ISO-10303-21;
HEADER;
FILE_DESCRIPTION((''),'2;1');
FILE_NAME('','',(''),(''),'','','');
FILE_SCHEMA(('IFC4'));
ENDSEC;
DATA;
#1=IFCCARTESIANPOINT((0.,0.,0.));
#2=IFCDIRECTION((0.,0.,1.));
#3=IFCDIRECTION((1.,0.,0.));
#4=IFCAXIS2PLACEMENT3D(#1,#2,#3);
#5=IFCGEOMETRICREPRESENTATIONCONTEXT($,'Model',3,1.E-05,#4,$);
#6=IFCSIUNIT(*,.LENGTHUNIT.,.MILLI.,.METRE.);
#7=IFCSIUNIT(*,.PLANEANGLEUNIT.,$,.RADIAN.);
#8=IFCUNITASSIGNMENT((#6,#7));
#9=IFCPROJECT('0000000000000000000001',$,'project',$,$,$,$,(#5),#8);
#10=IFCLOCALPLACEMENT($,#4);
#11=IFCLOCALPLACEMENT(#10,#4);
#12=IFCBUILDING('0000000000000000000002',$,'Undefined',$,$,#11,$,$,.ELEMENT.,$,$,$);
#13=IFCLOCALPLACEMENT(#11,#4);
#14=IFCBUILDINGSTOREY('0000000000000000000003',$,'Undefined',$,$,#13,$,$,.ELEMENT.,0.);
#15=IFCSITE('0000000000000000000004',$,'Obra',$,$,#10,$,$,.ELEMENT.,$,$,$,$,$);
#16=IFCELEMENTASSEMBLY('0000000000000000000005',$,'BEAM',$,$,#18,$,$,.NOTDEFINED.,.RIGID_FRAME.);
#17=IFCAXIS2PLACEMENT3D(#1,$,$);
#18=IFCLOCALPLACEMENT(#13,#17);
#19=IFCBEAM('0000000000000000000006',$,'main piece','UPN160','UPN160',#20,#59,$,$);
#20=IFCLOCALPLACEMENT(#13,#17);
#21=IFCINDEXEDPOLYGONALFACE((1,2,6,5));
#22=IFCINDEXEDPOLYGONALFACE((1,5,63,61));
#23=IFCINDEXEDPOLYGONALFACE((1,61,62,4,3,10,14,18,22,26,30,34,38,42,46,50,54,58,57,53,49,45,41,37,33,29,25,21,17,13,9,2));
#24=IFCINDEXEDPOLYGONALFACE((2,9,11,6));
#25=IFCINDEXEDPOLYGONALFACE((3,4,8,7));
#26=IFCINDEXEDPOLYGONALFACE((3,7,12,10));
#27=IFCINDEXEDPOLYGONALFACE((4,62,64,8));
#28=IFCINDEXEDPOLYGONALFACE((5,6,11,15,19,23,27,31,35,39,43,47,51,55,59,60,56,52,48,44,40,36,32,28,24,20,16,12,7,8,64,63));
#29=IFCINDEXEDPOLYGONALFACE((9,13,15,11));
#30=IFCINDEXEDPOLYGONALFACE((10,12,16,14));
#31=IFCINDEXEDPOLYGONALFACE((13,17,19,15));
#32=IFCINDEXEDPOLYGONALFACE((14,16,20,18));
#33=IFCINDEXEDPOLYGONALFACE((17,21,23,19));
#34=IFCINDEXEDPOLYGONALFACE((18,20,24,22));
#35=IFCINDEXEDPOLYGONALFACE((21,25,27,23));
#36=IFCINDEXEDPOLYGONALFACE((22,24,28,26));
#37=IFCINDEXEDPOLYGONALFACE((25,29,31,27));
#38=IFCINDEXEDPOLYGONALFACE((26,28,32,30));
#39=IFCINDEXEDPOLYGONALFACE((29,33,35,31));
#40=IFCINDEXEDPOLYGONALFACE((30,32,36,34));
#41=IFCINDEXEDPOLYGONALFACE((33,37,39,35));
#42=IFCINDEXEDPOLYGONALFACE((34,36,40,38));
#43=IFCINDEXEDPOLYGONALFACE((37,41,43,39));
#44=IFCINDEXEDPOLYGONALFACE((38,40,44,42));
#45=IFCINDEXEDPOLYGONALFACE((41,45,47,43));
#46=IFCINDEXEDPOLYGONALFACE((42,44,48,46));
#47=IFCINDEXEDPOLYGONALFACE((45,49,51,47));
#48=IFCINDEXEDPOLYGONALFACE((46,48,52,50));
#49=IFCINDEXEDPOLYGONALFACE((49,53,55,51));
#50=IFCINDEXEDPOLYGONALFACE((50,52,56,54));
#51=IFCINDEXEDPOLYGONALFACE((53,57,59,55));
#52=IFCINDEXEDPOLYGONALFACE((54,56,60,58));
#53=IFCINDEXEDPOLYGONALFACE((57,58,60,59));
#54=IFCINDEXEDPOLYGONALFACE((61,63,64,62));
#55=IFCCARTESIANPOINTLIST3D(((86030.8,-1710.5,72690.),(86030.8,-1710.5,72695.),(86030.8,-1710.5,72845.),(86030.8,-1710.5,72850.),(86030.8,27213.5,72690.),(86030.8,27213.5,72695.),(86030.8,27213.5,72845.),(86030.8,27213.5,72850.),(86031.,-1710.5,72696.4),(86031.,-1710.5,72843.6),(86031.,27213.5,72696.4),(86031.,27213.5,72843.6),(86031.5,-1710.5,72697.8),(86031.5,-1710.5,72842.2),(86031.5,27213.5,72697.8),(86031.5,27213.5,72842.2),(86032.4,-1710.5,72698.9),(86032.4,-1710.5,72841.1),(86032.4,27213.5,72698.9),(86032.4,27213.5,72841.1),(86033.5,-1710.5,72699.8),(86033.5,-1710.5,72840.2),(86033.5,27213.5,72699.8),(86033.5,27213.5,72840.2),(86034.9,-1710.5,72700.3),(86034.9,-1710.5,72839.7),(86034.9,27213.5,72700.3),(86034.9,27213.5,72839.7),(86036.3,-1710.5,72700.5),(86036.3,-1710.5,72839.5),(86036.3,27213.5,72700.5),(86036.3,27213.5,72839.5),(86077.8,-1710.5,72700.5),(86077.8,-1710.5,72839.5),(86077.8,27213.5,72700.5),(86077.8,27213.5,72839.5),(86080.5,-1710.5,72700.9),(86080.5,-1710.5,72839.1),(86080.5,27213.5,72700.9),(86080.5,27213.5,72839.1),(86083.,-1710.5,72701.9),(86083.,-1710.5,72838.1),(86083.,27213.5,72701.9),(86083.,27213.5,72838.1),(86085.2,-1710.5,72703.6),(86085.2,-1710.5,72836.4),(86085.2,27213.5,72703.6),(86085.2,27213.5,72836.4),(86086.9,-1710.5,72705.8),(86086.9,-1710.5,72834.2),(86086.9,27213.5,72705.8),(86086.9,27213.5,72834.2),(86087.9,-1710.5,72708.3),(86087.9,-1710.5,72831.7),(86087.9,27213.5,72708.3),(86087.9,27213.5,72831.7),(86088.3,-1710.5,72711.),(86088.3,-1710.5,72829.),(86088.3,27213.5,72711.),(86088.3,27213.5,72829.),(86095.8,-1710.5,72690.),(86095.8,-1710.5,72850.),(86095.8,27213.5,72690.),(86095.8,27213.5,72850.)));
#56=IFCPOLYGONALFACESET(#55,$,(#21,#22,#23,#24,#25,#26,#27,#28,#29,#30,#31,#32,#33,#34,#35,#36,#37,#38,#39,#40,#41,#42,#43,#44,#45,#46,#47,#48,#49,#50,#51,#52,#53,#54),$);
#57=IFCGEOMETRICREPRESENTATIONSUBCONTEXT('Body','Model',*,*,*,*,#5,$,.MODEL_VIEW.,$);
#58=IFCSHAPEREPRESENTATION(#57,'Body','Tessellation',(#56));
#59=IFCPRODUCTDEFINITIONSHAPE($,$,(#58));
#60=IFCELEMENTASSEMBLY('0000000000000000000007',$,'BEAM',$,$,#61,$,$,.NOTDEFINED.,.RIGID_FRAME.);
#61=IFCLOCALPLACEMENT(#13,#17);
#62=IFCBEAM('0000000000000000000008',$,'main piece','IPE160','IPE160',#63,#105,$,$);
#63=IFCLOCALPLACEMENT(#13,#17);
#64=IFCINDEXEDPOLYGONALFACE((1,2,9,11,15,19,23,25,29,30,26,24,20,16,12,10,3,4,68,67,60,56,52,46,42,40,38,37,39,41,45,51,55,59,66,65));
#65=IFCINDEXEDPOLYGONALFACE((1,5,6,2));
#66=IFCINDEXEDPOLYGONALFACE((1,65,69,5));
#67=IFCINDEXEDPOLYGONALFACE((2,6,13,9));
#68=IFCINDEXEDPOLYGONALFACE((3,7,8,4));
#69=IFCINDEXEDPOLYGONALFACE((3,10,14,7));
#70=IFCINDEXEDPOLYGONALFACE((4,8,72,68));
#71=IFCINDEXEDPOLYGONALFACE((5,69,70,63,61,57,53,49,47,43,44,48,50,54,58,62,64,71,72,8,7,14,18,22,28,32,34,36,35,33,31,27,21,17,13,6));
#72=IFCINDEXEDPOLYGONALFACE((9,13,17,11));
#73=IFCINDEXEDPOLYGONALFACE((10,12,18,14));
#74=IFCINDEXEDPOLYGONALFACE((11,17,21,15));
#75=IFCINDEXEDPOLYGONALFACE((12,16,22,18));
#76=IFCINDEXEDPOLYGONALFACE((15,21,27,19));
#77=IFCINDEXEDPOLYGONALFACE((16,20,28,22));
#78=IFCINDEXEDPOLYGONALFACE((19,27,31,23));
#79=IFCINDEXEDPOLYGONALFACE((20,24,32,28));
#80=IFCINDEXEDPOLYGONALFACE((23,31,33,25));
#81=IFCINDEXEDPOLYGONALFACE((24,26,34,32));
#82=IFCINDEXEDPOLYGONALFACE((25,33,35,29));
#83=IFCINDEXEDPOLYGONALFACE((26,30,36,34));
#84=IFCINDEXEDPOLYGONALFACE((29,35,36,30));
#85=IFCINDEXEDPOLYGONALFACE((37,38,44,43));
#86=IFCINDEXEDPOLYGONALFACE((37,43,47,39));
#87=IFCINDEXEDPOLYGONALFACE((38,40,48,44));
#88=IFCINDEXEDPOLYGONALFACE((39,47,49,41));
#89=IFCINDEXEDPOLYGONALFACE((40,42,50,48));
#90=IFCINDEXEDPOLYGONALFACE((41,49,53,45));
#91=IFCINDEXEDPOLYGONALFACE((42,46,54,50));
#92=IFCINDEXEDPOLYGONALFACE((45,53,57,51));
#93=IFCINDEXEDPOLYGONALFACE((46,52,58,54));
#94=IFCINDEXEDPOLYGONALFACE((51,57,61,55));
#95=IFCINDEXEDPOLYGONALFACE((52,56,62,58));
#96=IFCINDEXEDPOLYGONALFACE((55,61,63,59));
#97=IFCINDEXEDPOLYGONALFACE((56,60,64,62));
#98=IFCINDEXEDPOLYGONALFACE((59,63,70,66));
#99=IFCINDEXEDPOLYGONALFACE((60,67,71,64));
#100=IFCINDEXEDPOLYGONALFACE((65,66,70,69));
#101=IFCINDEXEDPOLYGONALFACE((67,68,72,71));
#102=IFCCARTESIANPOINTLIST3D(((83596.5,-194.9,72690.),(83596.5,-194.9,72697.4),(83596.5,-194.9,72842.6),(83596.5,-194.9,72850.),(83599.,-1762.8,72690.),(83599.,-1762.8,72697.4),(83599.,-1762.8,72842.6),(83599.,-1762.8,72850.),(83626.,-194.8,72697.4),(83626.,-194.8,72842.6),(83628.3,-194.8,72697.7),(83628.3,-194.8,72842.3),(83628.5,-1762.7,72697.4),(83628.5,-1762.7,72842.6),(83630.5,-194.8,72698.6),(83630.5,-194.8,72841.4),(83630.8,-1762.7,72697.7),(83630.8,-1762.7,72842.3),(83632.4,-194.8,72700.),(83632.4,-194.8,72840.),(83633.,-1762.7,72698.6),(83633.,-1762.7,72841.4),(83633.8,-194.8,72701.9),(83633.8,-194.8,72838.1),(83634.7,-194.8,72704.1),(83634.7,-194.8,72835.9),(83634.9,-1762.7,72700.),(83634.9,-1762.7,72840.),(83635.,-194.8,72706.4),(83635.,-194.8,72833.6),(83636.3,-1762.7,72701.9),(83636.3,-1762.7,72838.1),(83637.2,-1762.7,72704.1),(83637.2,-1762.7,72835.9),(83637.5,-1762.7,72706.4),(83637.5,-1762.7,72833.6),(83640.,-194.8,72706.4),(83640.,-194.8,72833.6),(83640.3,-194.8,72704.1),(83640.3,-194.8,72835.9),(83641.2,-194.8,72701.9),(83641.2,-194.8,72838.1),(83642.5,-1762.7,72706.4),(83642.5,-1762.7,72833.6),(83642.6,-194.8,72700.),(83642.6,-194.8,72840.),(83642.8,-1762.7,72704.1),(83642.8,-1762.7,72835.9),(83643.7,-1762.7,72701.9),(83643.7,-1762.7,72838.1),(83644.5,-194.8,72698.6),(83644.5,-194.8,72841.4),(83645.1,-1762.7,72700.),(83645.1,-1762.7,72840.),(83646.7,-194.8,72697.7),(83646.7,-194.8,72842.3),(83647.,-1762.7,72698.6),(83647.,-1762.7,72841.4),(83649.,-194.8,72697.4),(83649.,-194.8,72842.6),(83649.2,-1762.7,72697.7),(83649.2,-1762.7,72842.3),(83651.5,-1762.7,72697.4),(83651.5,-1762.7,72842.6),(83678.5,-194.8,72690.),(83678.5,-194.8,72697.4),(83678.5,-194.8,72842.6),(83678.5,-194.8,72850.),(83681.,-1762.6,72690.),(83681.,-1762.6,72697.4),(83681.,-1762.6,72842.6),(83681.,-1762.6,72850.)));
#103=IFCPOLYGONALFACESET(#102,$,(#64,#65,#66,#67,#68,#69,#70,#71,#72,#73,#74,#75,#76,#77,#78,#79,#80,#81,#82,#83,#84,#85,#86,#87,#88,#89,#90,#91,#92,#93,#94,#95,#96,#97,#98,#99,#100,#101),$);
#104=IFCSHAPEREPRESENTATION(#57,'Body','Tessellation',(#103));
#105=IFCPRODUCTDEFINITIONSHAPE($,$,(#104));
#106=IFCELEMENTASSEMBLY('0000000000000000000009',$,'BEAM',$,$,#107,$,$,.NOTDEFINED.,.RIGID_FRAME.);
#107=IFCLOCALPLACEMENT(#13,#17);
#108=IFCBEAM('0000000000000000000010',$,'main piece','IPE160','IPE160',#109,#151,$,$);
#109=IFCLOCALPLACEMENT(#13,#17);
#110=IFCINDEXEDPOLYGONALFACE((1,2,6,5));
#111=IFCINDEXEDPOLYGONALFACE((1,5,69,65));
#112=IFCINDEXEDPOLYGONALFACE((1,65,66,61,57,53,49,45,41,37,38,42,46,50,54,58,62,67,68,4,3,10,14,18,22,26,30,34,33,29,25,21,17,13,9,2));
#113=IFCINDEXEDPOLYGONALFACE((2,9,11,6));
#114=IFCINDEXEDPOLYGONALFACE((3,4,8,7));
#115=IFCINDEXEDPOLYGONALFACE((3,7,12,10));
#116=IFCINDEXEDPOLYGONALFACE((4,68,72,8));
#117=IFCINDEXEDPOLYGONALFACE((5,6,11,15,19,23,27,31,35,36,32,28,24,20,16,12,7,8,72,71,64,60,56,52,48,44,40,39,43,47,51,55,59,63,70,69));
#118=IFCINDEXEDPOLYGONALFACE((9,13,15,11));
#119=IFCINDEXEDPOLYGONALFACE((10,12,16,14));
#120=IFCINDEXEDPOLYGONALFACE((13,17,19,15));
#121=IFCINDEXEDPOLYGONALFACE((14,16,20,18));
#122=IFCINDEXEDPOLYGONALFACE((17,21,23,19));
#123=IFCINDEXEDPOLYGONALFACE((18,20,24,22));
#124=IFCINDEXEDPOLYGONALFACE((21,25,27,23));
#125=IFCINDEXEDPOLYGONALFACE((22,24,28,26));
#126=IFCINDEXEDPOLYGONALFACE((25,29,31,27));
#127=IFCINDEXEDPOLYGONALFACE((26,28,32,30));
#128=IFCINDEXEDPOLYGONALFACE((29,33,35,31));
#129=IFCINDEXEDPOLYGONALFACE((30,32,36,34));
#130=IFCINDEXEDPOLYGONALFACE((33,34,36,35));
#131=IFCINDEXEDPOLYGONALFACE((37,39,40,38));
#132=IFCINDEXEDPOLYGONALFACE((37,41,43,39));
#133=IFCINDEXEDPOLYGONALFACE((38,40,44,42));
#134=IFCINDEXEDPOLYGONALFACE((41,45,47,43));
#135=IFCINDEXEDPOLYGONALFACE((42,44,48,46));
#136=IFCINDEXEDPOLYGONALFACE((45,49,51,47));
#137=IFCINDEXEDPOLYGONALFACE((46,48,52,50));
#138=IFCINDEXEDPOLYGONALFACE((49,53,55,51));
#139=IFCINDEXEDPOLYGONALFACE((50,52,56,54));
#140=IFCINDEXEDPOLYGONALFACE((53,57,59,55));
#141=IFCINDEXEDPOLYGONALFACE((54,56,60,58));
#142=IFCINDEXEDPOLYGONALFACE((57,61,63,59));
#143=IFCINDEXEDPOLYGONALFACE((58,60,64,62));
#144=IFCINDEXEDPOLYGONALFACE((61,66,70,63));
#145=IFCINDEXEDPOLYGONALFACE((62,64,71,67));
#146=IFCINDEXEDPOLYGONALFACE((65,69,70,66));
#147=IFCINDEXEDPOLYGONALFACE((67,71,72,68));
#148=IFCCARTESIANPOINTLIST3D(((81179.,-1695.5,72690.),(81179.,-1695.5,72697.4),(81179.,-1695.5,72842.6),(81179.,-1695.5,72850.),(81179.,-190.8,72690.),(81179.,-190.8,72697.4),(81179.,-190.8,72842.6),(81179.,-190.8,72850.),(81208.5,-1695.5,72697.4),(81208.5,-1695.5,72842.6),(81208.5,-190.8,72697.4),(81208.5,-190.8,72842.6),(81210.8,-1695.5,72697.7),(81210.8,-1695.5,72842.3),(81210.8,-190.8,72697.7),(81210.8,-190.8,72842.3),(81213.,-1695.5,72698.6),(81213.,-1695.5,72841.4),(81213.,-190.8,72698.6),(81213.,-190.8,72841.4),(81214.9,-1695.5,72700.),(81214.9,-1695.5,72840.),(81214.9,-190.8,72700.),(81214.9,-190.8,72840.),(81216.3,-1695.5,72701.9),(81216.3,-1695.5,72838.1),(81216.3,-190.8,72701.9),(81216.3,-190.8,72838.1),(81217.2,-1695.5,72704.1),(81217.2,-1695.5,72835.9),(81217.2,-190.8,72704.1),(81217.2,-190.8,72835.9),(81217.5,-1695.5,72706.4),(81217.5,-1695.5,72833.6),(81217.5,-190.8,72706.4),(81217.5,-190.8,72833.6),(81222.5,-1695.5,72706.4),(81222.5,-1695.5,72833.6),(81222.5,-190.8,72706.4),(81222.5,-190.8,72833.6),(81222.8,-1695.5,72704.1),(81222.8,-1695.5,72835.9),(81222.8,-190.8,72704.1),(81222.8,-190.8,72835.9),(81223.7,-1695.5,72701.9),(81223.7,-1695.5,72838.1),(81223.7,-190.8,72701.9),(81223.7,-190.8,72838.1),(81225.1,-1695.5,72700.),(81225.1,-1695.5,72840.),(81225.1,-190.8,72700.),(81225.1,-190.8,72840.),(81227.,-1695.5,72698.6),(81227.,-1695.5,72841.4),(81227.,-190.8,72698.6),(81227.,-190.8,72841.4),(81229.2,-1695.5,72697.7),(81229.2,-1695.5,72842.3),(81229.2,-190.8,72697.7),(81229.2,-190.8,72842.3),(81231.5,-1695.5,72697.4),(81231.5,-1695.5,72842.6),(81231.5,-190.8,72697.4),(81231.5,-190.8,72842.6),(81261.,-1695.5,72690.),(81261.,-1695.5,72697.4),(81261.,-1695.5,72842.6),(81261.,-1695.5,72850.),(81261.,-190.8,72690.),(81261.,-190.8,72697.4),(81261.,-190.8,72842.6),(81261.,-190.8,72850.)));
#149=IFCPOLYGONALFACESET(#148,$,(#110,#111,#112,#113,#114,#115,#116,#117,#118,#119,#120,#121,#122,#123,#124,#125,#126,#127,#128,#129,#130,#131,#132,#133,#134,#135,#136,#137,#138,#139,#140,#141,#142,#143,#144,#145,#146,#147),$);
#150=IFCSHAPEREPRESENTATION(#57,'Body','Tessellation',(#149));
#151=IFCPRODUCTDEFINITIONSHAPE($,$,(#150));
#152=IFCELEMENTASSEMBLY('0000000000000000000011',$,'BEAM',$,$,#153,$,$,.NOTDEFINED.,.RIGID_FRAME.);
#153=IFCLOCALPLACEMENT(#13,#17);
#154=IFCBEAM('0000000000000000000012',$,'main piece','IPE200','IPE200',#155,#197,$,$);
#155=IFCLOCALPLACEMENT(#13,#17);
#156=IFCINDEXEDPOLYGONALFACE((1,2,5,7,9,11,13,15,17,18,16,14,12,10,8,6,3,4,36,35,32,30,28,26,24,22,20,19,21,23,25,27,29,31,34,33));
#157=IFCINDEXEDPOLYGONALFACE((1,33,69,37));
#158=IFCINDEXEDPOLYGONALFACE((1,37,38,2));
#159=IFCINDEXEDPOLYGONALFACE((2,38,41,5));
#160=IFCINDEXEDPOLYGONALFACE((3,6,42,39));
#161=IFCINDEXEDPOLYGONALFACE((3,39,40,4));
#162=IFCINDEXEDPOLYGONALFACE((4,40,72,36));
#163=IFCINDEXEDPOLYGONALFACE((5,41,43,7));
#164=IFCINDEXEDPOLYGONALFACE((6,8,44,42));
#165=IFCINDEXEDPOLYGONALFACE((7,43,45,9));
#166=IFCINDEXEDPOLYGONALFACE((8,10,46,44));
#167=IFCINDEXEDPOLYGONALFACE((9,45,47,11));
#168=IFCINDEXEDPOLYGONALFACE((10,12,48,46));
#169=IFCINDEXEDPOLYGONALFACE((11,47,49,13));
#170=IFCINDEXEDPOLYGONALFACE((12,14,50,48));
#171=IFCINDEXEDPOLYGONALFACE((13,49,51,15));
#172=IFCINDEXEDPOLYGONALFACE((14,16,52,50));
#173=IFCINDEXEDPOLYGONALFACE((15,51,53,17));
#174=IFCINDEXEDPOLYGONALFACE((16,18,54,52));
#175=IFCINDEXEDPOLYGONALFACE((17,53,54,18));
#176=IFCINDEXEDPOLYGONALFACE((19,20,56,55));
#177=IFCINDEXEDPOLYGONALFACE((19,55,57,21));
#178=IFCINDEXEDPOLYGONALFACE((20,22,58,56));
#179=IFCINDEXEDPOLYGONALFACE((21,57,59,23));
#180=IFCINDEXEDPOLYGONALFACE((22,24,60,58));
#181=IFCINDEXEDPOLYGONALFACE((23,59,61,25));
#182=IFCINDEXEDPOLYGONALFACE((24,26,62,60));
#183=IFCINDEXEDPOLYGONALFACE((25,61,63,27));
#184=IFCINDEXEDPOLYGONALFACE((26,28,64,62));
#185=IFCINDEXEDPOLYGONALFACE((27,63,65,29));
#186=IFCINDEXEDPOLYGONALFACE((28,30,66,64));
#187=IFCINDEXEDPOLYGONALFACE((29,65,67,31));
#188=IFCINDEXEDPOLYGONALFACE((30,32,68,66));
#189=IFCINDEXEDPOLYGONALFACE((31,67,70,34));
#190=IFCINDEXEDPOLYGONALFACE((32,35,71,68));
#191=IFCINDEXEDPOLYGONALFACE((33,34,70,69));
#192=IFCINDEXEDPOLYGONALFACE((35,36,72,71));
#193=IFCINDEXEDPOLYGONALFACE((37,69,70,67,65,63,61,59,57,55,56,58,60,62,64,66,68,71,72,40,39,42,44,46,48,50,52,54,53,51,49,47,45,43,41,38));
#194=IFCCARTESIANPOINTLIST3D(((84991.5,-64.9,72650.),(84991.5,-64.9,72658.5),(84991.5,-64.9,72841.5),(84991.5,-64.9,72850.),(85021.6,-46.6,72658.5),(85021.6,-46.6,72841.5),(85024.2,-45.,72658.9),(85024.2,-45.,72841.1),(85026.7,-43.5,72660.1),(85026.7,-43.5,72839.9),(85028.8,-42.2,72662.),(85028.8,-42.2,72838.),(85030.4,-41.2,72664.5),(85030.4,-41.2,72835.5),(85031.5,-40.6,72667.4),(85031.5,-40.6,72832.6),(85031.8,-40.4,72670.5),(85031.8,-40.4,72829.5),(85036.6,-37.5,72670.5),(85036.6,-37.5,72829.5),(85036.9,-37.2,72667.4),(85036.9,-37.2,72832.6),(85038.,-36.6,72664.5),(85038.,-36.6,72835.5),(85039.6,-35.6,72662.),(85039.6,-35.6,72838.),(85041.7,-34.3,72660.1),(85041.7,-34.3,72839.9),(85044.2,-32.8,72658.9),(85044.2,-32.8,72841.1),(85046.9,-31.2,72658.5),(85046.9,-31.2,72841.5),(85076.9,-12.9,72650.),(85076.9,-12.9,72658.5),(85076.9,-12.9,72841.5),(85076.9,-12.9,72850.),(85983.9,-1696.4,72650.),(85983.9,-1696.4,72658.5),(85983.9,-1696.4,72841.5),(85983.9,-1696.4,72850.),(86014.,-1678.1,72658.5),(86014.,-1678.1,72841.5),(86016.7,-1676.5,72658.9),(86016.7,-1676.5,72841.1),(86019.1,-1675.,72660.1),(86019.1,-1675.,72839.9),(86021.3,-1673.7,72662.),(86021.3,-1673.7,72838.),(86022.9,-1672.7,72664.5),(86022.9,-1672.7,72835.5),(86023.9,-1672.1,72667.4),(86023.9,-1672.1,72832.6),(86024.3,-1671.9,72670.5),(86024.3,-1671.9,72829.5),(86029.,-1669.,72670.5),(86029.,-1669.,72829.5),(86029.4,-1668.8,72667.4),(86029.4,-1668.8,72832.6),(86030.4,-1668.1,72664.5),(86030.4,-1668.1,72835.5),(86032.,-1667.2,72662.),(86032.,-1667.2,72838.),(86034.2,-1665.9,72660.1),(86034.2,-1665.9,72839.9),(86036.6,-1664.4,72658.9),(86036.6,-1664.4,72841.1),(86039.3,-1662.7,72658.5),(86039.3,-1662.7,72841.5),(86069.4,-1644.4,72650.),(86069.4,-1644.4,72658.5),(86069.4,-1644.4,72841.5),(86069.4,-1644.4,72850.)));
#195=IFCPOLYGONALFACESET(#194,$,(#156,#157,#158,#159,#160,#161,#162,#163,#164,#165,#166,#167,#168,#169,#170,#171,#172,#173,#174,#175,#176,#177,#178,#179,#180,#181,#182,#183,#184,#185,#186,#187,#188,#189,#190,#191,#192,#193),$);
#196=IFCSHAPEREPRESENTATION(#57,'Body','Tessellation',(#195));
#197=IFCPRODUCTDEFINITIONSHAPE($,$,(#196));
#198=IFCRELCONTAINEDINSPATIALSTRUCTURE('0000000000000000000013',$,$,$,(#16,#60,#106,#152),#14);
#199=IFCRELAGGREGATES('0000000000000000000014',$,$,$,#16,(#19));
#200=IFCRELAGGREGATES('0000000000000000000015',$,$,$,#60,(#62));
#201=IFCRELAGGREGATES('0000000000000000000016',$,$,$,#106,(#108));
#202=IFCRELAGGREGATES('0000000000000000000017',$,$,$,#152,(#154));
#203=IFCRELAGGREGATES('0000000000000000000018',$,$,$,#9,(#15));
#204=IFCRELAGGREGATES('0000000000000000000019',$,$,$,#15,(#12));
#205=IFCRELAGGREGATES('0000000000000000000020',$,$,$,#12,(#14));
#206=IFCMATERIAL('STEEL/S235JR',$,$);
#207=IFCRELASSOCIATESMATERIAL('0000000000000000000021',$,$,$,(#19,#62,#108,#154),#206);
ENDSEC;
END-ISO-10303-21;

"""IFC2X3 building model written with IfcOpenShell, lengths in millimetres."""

from ifc_helpers import new_model, si_unit, frame, origin_with_axes, origin_2d_with_axis, place, context, subcontext, project, spatial, i_section, u_section, extrude, material, element, aggregate, save


model = new_model("IFC2X3")

# Units and contexts
model_context = context("Model", 3, precision=1e-05, world=origin_with_axes())
body_context = subcontext(model_context, "Body", "Model", "MODEL_VIEW")
ifc_project = project(units=[si_unit("LENGTHUNIT", "METRE", prefix="MILLI"), si_unit("PLANEANGLEUNIT", "RADIAN")], contexts=[model_context])

# Site, building, storey
site_placement = place(None, origin_with_axes())
site = spatial("IfcSite", under=ifc_project, at=site_placement, Name="Obra", CompositionType="ELEMENT")
building_placement = place(site_placement, origin_with_axes())
building = spatial("IfcBuilding", under=site, at=building_placement, Name="Undefined", CompositionType="ELEMENT")
storey_placement = place(building_placement, origin_with_axes())
storey = spatial("IfcBuildingStorey", under=building, at=storey_placement, Name="Undefined", CompositionType="ELEMENT", Elevation=0.0)

# Element assemblies, beams
assembly_1_placement = place(storey_placement, origin_with_axes())
assembly_1 = element("IfcElementAssembly", 1, at=assembly_1_placement, inside=storey, Name="BEAM", AssemblyPlace="NOTDEFINED", PredefinedType="RIGID_FRAME")
ifc_material = material(Name="STEEL/S235JR")
beam_1_placement = place(assembly_1_placement, frame((86063.3, -1710.5, 72770.0), z_axis=(0.0, 0.0, -1.0), x_axis=(0.0, 1.0, 0.0)))
beam_1 = element("IfcBeam", 2, at=beam_1_placement, material=ifc_material, Name="main piece", Description="UPN160", ObjectType="UPN160", context=body_context, shape_type="SweptSolid", body=[
    extrude(u_section(Depth=160.0, FlangeWidth=65.0, WebThickness=7.5, FlangeThickness=10.5, FilletRadius=10.5, EdgeRadius=5.5, at=origin_2d_with_axis()), frame((28924.0, 0.0, 0.0), z_axis=(-1.0, 0.0, 0.0), x_axis=(0.0, -1.0, 0.0)), (0.0, 0.0, 1.0), 28924.0),
])
aggregate(assembly_1, [beam_1])
assembly_2_placement = place(storey_placement, origin_with_axes())
assembly_2 = element("IfcElementAssembly", 3, at=assembly_2_placement, inside=storey, Name="BEAM", AssemblyPlace="NOTDEFINED", PredefinedType="RIGID_FRAME")
beam_2_placement = place(assembly_2_placement, frame((83637.5, -194.8, 72770.0), z_axis=(0.0, 0.0, 1.0), x_axis=(0.001595, -0.999999, 0.0)))
beam_2 = element("IfcBeam", 4, at=beam_2_placement, material=ifc_material, Name="main piece", Description="IPE160", ObjectType="IPE160", context=body_context, shape_type="SweptSolid", body=[
    extrude(i_section(OverallWidth=82.0, OverallDepth=160.0, WebThickness=5.0, FlangeThickness=7.4, FilletRadius=9.0, at=origin_2d_with_axis()), frame((1567.9, 0.0, 0.0), z_axis=(-1.0, 0.0, 0.0), x_axis=(0.0, -1.0, 0.0)), (0.0, 0.0, 1.0), 1567.9),
])
aggregate(assembly_2, [beam_2])
assembly_3_placement = place(storey_placement, origin_with_axes())
assembly_3 = element("IfcElementAssembly", 5, at=assembly_3_placement, inside=storey, Name="BEAM", AssemblyPlace="NOTDEFINED", PredefinedType="RIGID_FRAME")
beam_3_placement = place(assembly_3_placement, frame((81220.0, -190.8, 72770.0), z_axis=(0.0, 0.0, 1.0), x_axis=(-0.000003, -1.0, 0.0)))
beam_3 = element("IfcBeam", 6, at=beam_3_placement, material=ifc_material, Name="main piece", Description="IPE160", ObjectType="IPE160", context=body_context, shape_type="SweptSolid", body=[
    extrude(i_section(OverallWidth=82.0, OverallDepth=160.0, WebThickness=5.0, FlangeThickness=7.4, FilletRadius=9.0, at=origin_2d_with_axis()), frame((1504.7, 0.0, 0.0), z_axis=(-1.0, 0.0, 0.0), x_axis=(0.0, -1.0, 0.0)), (0.0, 0.0, 1.0), 1504.7),
])
aggregate(assembly_3, [beam_3])
assembly_4_placement = place(storey_placement, origin_with_axes())
assembly_4 = element("IfcElementAssembly", 7, at=assembly_4_placement, inside=storey, Name="BEAM", AssemblyPlace="NOTDEFINED", PredefinedType="RIGID_FRAME")
beam_4_placement = place(assembly_4_placement, frame((85034.2, -38.9, 72750.0), z_axis=(0.0, 0.0, 1.0), x_axis=(0.519695, -0.854352, 0.0)))
beam_4 = element("IfcBeam", 8, at=beam_4_placement, material=ifc_material, Name="main piece", Description="IPE200", ObjectType="IPE200", context=body_context, shape_type="SweptSolid", body=[
    extrude(i_section(OverallWidth=100.0, OverallDepth=200.0, WebThickness=5.6, FlangeThickness=8.5, FilletRadius=12.0, at=origin_2d_with_axis()), frame((1909.7, 0.0, 0.0), z_axis=(-1.0, 0.0, 0.0), x_axis=(0.0, -1.0, 0.0)), (0.0, 0.0, 1.0), 1909.7),
])
aggregate(assembly_4, [beam_4])

save(model, "model.ifc")
